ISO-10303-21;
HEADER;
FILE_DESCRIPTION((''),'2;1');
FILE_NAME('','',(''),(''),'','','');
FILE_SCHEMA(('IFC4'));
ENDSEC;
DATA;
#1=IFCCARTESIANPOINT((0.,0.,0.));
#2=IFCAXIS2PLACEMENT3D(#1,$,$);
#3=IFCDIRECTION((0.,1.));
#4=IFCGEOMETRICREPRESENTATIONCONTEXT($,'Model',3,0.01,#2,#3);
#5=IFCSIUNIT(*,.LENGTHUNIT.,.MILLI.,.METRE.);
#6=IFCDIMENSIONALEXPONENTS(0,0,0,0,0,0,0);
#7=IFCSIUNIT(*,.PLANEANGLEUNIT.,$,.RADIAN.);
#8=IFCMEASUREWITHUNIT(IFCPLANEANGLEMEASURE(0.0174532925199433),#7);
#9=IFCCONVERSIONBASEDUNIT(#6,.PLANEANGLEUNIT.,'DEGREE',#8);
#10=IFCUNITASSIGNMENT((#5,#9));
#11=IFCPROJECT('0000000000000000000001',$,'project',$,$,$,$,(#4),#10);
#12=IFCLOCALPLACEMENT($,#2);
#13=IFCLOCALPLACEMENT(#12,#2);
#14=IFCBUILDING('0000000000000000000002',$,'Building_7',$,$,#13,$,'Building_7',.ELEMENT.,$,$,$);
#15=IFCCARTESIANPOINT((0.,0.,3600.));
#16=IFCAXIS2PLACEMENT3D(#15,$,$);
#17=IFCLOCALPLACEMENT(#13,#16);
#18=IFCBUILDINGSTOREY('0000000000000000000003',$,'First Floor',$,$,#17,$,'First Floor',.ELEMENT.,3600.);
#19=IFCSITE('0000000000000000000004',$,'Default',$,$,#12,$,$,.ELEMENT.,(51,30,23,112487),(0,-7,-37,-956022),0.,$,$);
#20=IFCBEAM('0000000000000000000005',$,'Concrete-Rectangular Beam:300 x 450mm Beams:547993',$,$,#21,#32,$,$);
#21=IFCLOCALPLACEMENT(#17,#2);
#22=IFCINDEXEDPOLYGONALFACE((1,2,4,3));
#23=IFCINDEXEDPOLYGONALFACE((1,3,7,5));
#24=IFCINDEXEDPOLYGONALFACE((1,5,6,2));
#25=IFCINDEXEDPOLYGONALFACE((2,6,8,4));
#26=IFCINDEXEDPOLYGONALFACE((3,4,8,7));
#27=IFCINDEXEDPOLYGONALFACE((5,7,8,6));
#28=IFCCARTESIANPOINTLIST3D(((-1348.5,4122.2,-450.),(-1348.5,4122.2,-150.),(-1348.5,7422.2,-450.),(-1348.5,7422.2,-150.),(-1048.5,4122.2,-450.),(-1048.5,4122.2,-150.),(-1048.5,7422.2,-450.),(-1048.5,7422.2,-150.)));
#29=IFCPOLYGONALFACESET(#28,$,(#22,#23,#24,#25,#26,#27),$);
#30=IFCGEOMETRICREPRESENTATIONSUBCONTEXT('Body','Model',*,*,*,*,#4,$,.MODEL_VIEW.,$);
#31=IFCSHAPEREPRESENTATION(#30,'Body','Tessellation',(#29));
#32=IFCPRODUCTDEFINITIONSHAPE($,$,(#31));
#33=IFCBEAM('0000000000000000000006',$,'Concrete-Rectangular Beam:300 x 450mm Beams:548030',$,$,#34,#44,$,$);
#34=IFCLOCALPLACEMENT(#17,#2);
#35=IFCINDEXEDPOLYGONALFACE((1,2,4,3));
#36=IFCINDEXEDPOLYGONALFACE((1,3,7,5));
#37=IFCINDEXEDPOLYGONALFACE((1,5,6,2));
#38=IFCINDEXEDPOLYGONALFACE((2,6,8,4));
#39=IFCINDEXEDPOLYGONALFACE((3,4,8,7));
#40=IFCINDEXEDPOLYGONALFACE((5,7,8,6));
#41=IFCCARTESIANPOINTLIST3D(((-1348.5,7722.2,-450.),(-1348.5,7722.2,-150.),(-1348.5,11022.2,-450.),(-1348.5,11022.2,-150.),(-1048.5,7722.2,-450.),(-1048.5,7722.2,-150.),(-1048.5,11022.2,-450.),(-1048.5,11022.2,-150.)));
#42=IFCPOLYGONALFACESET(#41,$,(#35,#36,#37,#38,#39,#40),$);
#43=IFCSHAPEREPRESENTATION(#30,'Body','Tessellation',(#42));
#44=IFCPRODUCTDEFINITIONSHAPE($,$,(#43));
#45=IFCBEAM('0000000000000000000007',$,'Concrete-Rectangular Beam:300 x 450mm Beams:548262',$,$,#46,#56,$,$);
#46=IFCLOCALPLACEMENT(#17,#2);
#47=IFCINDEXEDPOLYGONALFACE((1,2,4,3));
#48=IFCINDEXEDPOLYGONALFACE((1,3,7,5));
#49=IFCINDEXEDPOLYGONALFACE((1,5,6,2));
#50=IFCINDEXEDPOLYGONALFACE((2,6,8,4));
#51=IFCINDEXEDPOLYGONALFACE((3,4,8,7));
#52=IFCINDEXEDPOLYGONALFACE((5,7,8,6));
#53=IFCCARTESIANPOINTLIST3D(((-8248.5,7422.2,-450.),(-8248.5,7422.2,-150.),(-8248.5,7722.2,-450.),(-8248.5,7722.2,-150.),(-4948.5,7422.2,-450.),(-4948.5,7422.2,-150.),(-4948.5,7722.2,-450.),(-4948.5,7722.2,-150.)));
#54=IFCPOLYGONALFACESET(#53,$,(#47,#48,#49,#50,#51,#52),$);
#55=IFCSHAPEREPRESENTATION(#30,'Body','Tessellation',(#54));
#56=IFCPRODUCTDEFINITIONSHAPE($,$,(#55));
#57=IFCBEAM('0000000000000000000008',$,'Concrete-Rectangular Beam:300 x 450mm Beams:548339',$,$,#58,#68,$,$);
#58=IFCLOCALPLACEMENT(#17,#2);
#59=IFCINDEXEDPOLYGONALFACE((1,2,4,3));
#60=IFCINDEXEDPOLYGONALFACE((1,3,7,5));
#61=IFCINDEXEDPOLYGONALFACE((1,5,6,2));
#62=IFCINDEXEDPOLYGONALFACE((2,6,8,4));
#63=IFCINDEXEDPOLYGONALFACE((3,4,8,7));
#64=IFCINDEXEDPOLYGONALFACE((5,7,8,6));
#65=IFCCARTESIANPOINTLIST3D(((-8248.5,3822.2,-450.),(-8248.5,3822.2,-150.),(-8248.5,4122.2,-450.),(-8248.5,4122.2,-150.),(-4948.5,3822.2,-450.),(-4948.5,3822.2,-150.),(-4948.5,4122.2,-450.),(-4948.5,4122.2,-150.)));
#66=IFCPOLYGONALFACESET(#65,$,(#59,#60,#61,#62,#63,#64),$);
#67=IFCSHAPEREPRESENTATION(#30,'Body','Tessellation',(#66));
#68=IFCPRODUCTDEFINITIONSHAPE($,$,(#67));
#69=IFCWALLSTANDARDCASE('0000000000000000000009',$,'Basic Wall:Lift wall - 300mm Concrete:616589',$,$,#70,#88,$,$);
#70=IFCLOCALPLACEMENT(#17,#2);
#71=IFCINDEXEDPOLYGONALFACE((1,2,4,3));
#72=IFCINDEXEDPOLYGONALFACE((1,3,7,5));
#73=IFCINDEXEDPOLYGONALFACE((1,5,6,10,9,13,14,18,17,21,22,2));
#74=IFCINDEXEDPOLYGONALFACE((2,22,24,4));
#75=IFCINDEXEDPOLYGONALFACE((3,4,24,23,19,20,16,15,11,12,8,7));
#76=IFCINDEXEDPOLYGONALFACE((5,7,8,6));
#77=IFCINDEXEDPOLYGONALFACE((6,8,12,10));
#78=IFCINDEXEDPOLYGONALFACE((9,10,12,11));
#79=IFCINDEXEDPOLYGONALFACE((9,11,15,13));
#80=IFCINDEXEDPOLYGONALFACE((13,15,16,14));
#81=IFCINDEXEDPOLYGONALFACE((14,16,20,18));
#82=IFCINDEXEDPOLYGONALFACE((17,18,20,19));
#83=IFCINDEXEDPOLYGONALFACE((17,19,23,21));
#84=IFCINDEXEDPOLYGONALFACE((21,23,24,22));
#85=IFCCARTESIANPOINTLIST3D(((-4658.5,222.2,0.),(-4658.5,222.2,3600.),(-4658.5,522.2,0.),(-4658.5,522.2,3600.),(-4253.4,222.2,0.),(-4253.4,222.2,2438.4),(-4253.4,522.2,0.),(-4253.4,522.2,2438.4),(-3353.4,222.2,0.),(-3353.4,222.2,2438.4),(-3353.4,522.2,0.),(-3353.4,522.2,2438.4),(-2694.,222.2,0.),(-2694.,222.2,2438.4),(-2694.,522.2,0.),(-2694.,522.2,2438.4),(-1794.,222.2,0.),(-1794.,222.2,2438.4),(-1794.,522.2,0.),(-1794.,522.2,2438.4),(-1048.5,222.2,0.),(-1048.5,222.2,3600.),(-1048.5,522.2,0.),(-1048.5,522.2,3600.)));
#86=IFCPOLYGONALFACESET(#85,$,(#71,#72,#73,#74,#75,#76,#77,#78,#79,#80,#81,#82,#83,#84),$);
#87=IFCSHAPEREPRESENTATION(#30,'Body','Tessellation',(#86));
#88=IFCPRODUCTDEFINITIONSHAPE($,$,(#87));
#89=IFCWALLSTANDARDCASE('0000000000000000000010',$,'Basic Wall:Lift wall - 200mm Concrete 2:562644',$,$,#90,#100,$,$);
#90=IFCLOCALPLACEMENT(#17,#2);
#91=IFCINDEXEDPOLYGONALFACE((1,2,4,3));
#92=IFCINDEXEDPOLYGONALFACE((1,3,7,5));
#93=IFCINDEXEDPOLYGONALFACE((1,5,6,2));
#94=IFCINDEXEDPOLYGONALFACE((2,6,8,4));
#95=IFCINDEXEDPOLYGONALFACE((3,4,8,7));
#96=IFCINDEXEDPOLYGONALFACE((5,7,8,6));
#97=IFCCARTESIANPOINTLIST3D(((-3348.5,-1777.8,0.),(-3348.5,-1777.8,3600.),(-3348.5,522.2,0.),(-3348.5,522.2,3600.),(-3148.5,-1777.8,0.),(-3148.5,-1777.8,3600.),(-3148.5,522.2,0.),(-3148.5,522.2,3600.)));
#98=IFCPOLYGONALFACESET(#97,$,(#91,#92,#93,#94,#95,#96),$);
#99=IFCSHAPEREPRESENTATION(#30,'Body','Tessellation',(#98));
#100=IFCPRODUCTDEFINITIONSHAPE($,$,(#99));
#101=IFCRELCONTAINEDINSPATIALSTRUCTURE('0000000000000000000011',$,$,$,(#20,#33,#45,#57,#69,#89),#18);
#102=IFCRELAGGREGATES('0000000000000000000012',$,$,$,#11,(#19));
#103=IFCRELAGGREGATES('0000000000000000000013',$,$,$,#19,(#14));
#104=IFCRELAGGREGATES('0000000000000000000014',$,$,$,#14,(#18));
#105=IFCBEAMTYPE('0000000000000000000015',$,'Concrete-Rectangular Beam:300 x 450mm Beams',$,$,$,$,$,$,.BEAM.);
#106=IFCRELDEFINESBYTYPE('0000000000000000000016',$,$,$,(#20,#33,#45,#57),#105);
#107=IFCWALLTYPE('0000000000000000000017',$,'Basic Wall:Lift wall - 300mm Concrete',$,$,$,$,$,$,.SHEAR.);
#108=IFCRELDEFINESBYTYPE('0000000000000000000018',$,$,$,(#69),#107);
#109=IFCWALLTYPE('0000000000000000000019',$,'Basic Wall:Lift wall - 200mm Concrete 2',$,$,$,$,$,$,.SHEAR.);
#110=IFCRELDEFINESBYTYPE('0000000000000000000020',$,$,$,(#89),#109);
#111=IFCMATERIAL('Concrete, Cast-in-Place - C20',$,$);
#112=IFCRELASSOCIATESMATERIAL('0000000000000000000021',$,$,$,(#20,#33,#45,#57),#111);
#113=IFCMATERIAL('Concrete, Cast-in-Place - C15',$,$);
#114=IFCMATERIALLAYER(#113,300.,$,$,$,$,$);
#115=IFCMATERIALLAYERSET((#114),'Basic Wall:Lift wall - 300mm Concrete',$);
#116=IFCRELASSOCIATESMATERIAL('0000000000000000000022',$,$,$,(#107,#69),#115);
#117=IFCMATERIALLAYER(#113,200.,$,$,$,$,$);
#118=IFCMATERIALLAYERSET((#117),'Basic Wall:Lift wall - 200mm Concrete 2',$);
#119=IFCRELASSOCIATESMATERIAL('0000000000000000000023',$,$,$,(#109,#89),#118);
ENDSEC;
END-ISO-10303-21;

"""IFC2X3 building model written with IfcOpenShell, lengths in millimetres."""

from ifc_helpers import new_model, entity, si_unit, converted_unit, direction, frame, frame_2d, origin, origin_2d_with_axis, place, context, subcontext, project, spatial, rectangle, extrude, material, layer, layer_set, layer_usage, type_object, element, save


model = new_model("IFC2X3")

# Units and contexts
model_context = context("Model", 3, precision=0.01, world=origin(), true_north=direction((0.0, 1.0)))
body_context = subcontext(model_context, "Body", "Model", "MODEL_VIEW")
ifc_project = project(units=[si_unit("LENGTHUNIT", "METRE", prefix="MILLI"), converted_unit("PLANEANGLEUNIT", "DEGREE", entity("IfcPlaneAngleMeasure", 0.0174532925199433), si_unit("PLANEANGLEUNIT", "RADIAN"), dimensions=[0, 0, 0, 0, 0, 0, 0])], contexts=[model_context])

# Site, building, storey
site_placement = place(None, origin())
site = spatial("IfcSite", under=ifc_project, at=site_placement, Name="Default", CompositionType="ELEMENT", RefLatitude=(51, 30, 23, 112487), RefLongitude=(0, -7, -37, -956022), RefElevation=0.0)
building_placement = place(site_placement, origin())
building = spatial("IfcBuilding", under=site, at=building_placement, Name="Building_7", LongName="Building_7", CompositionType="ELEMENT")
storey_placement = place(building_placement, frame((0.0, 0.0, 3600.0)))
storey = spatial("IfcBuildingStorey", under=building, at=storey_placement, Name="First Floor", LongName="First Floor", CompositionType="ELEMENT", Elevation=3600.0)

# Beams
ifc_material_1 = material(Name="Concrete, Cast-in-Place - C20")
beam_type = type_object("IfcBeamType", Name="Concrete-Rectangular Beam:300 x 450mm Beams", PredefinedType="BEAM")
beam_1_placement = place(storey_placement, frame((-1198.5, 3972.2, 0.0), z_axis=(0.0, 0.0, 1.0), x_axis=(0.0, 1.0, 0.0)))
element("IfcBeam", 1, at=beam_1_placement, inside=storey, type_object=beam_type, material=ifc_material_1, Name="Concrete-Rectangular Beam:300 x 450mm Beams:547993", context=body_context, shape_type="SweptSolid", body=[
    extrude(rectangle(XDim=300.0, YDim=300.0, at=frame_2d((0.0, 0.0), x_axis=(1.0, 0.0))), frame((150.0, 0.0, -300.0), z_axis=(1.0, 0.0, 0.0), x_axis=(0.0, 0.0, -1.0)), (0.0, 0.0, 1.0), 3300.0),
])
beam_2_placement = place(storey_placement, frame((-1198.5, 11172.2, 0.0), z_axis=(0.0, 0.0, 1.0), x_axis=(0.0, -1.0, 0.0)))
element("IfcBeam", 2, at=beam_2_placement, inside=storey, type_object=beam_type, material=ifc_material_1, Name="Concrete-Rectangular Beam:300 x 450mm Beams:548030", context=body_context, shape_type="SweptSolid", body=[
    extrude(rectangle(XDim=300.0, YDim=300.0, at=origin_2d_with_axis()), frame((150.0, 0.0, -300.0), z_axis=(1.0, 0.0, 0.0), x_axis=(0.0, 0.0, -1.0)), (0.0, 0.0, 1.0), 3300.0),
])
beam_3_placement = place(storey_placement, frame((-4798.5, 7572.2, 0.0), z_axis=(0.0, 0.0, 1.0), x_axis=(-1.0, 0.0, 0.0)))
element("IfcBeam", 3, at=beam_3_placement, inside=storey, type_object=beam_type, material=ifc_material_1, Name="Concrete-Rectangular Beam:300 x 450mm Beams:548262", context=body_context, shape_type="SweptSolid", body=[
    extrude(rectangle(XDim=300.0, YDim=300.0, at=frame_2d((0.0, 0.0), x_axis=(1.0, 0.0))), frame((150.0, 0.0, -300.0), z_axis=(1.0, 0.0, 0.0), x_axis=(0.0, 0.0, -1.0)), (0.0, 0.0, 1.0), 3300.0),
])
beam_4_placement = place(storey_placement, frame((-4798.5, 3972.2, 0.0), z_axis=(0.0, 0.0, 1.0), x_axis=(-1.0, 0.0, 0.0)))
element("IfcBeam", 4, at=beam_4_placement, inside=storey, type_object=beam_type, material=ifc_material_1, Name="Concrete-Rectangular Beam:300 x 450mm Beams:548339", context=body_context, shape_type="SweptSolid", body=[
    extrude(rectangle(XDim=300.0, YDim=300.0, at=frame_2d((0.0, 0.0), x_axis=(1.0, 0.0))), frame((150.0, 0.0, -300.0), z_axis=(1.0, 0.0, 0.0), x_axis=(0.0, 0.0, -1.0)), (0.0, 0.0, 1.0), 3300.0),
])

# Wall, openings
ifc_material_2 = material(Name="Concrete, Cast-in-Place - C15")
ifc_layer_1 = layer(ifc_material_2, 300.0)
ifc_layer_set_1 = layer_set([ifc_layer_1], Name="Basic Wall:Lift wall - 300mm Concrete")
ifc_layer_usage_1 = layer_usage(ifc_layer_set_1, "AXIS2", "NEGATIVE", 150.0)
wall_type_1 = type_object("IfcWallType", Name="Basic Wall:Lift wall - 300mm Concrete", PredefinedType="SHEAR", material=ifc_layer_set_1)
wall_1_placement = place(storey_placement, frame((-1048.5, 372.2, 0.0), z_axis=(0.0, 0.0, 1.0), x_axis=(-1.0, 0.0, 0.0)))
wall_1 = element("IfcWallStandardCase", 5, at=wall_1_placement, inside=storey, type_object=wall_type_1, material=ifc_layer_usage_1, Name="Basic Wall:Lift wall - 300mm Concrete:616589", context=body_context, shape_type="SweptSolid", body=[
    extrude(rectangle(XDim=3610.0, YDim=300.0, at=frame_2d((1805.0, 0.0), x_axis=(1.0, 0.0))), origin(), (0.0, 0.0, 1.0), 3600.0),
])
opening_1_placement = place(wall_1_placement, origin())
element("IfcOpeningElement", 6, at=opening_1_placement, cuts=wall_1, ObjectType="Opening", context=body_context, shape_type="SweptSolid", body=[
    extrude(rectangle(XDim=2438.4, YDim=900.0, at=frame_2d((0.0, 0.0), x_axis=(1.0, 0.0))), frame((1195.6, -150.0, 1219.2), z_axis=(0.0, 1.0, 0.0), x_axis=(0.0, 0.0, -1.0)), (0.0, 0.0, 1.0), 300.0),
])
opening_2_placement = place(wall_1_placement, origin())
element("IfcOpeningElement", 7, at=opening_2_placement, cuts=wall_1, ObjectType="Opening", context=body_context, shape_type="SweptSolid", body=[
    extrude(rectangle(XDim=2438.4, YDim=900.0, at=origin_2d_with_axis()), frame((2755.0, -150.0, 1219.2), z_axis=(0.0, 1.0, 0.0), x_axis=(0.0, 0.0, -1.0)), (0.0, 0.0, 1.0), 300.0),
])

# Wall
ifc_layer_2 = layer(ifc_material_2, 200.0)
ifc_layer_set_2 = layer_set([ifc_layer_2], Name="Basic Wall:Lift wall - 200mm Concrete 2")
ifc_layer_usage_2 = layer_usage(ifc_layer_set_2, "AXIS2", "NEGATIVE", 100.0)
wall_type_2 = type_object("IfcWallType", Name="Basic Wall:Lift wall - 200mm Concrete 2", PredefinedType="SHEAR", material=ifc_layer_set_2)
wall_2_placement = place(storey_placement, frame((-3248.5, 522.2, 0.0), z_axis=(0.0, 0.0, 1.0), x_axis=(0.0, -1.0, 0.0)))
element("IfcWallStandardCase", 8, at=wall_2_placement, inside=storey, type_object=wall_type_2, material=ifc_layer_usage_2, Name="Basic Wall:Lift wall - 200mm Concrete 2:562644", context=body_context, shape_type="SweptSolid", body=[
    extrude(rectangle(XDim=2300.0, YDim=200.0, at=frame_2d((1150.0, 0.0), x_axis=(-1.0, 0.0))), origin(), (0.0, 0.0, 1.0), 3600.0),
])

save(model, "model.ifc")
